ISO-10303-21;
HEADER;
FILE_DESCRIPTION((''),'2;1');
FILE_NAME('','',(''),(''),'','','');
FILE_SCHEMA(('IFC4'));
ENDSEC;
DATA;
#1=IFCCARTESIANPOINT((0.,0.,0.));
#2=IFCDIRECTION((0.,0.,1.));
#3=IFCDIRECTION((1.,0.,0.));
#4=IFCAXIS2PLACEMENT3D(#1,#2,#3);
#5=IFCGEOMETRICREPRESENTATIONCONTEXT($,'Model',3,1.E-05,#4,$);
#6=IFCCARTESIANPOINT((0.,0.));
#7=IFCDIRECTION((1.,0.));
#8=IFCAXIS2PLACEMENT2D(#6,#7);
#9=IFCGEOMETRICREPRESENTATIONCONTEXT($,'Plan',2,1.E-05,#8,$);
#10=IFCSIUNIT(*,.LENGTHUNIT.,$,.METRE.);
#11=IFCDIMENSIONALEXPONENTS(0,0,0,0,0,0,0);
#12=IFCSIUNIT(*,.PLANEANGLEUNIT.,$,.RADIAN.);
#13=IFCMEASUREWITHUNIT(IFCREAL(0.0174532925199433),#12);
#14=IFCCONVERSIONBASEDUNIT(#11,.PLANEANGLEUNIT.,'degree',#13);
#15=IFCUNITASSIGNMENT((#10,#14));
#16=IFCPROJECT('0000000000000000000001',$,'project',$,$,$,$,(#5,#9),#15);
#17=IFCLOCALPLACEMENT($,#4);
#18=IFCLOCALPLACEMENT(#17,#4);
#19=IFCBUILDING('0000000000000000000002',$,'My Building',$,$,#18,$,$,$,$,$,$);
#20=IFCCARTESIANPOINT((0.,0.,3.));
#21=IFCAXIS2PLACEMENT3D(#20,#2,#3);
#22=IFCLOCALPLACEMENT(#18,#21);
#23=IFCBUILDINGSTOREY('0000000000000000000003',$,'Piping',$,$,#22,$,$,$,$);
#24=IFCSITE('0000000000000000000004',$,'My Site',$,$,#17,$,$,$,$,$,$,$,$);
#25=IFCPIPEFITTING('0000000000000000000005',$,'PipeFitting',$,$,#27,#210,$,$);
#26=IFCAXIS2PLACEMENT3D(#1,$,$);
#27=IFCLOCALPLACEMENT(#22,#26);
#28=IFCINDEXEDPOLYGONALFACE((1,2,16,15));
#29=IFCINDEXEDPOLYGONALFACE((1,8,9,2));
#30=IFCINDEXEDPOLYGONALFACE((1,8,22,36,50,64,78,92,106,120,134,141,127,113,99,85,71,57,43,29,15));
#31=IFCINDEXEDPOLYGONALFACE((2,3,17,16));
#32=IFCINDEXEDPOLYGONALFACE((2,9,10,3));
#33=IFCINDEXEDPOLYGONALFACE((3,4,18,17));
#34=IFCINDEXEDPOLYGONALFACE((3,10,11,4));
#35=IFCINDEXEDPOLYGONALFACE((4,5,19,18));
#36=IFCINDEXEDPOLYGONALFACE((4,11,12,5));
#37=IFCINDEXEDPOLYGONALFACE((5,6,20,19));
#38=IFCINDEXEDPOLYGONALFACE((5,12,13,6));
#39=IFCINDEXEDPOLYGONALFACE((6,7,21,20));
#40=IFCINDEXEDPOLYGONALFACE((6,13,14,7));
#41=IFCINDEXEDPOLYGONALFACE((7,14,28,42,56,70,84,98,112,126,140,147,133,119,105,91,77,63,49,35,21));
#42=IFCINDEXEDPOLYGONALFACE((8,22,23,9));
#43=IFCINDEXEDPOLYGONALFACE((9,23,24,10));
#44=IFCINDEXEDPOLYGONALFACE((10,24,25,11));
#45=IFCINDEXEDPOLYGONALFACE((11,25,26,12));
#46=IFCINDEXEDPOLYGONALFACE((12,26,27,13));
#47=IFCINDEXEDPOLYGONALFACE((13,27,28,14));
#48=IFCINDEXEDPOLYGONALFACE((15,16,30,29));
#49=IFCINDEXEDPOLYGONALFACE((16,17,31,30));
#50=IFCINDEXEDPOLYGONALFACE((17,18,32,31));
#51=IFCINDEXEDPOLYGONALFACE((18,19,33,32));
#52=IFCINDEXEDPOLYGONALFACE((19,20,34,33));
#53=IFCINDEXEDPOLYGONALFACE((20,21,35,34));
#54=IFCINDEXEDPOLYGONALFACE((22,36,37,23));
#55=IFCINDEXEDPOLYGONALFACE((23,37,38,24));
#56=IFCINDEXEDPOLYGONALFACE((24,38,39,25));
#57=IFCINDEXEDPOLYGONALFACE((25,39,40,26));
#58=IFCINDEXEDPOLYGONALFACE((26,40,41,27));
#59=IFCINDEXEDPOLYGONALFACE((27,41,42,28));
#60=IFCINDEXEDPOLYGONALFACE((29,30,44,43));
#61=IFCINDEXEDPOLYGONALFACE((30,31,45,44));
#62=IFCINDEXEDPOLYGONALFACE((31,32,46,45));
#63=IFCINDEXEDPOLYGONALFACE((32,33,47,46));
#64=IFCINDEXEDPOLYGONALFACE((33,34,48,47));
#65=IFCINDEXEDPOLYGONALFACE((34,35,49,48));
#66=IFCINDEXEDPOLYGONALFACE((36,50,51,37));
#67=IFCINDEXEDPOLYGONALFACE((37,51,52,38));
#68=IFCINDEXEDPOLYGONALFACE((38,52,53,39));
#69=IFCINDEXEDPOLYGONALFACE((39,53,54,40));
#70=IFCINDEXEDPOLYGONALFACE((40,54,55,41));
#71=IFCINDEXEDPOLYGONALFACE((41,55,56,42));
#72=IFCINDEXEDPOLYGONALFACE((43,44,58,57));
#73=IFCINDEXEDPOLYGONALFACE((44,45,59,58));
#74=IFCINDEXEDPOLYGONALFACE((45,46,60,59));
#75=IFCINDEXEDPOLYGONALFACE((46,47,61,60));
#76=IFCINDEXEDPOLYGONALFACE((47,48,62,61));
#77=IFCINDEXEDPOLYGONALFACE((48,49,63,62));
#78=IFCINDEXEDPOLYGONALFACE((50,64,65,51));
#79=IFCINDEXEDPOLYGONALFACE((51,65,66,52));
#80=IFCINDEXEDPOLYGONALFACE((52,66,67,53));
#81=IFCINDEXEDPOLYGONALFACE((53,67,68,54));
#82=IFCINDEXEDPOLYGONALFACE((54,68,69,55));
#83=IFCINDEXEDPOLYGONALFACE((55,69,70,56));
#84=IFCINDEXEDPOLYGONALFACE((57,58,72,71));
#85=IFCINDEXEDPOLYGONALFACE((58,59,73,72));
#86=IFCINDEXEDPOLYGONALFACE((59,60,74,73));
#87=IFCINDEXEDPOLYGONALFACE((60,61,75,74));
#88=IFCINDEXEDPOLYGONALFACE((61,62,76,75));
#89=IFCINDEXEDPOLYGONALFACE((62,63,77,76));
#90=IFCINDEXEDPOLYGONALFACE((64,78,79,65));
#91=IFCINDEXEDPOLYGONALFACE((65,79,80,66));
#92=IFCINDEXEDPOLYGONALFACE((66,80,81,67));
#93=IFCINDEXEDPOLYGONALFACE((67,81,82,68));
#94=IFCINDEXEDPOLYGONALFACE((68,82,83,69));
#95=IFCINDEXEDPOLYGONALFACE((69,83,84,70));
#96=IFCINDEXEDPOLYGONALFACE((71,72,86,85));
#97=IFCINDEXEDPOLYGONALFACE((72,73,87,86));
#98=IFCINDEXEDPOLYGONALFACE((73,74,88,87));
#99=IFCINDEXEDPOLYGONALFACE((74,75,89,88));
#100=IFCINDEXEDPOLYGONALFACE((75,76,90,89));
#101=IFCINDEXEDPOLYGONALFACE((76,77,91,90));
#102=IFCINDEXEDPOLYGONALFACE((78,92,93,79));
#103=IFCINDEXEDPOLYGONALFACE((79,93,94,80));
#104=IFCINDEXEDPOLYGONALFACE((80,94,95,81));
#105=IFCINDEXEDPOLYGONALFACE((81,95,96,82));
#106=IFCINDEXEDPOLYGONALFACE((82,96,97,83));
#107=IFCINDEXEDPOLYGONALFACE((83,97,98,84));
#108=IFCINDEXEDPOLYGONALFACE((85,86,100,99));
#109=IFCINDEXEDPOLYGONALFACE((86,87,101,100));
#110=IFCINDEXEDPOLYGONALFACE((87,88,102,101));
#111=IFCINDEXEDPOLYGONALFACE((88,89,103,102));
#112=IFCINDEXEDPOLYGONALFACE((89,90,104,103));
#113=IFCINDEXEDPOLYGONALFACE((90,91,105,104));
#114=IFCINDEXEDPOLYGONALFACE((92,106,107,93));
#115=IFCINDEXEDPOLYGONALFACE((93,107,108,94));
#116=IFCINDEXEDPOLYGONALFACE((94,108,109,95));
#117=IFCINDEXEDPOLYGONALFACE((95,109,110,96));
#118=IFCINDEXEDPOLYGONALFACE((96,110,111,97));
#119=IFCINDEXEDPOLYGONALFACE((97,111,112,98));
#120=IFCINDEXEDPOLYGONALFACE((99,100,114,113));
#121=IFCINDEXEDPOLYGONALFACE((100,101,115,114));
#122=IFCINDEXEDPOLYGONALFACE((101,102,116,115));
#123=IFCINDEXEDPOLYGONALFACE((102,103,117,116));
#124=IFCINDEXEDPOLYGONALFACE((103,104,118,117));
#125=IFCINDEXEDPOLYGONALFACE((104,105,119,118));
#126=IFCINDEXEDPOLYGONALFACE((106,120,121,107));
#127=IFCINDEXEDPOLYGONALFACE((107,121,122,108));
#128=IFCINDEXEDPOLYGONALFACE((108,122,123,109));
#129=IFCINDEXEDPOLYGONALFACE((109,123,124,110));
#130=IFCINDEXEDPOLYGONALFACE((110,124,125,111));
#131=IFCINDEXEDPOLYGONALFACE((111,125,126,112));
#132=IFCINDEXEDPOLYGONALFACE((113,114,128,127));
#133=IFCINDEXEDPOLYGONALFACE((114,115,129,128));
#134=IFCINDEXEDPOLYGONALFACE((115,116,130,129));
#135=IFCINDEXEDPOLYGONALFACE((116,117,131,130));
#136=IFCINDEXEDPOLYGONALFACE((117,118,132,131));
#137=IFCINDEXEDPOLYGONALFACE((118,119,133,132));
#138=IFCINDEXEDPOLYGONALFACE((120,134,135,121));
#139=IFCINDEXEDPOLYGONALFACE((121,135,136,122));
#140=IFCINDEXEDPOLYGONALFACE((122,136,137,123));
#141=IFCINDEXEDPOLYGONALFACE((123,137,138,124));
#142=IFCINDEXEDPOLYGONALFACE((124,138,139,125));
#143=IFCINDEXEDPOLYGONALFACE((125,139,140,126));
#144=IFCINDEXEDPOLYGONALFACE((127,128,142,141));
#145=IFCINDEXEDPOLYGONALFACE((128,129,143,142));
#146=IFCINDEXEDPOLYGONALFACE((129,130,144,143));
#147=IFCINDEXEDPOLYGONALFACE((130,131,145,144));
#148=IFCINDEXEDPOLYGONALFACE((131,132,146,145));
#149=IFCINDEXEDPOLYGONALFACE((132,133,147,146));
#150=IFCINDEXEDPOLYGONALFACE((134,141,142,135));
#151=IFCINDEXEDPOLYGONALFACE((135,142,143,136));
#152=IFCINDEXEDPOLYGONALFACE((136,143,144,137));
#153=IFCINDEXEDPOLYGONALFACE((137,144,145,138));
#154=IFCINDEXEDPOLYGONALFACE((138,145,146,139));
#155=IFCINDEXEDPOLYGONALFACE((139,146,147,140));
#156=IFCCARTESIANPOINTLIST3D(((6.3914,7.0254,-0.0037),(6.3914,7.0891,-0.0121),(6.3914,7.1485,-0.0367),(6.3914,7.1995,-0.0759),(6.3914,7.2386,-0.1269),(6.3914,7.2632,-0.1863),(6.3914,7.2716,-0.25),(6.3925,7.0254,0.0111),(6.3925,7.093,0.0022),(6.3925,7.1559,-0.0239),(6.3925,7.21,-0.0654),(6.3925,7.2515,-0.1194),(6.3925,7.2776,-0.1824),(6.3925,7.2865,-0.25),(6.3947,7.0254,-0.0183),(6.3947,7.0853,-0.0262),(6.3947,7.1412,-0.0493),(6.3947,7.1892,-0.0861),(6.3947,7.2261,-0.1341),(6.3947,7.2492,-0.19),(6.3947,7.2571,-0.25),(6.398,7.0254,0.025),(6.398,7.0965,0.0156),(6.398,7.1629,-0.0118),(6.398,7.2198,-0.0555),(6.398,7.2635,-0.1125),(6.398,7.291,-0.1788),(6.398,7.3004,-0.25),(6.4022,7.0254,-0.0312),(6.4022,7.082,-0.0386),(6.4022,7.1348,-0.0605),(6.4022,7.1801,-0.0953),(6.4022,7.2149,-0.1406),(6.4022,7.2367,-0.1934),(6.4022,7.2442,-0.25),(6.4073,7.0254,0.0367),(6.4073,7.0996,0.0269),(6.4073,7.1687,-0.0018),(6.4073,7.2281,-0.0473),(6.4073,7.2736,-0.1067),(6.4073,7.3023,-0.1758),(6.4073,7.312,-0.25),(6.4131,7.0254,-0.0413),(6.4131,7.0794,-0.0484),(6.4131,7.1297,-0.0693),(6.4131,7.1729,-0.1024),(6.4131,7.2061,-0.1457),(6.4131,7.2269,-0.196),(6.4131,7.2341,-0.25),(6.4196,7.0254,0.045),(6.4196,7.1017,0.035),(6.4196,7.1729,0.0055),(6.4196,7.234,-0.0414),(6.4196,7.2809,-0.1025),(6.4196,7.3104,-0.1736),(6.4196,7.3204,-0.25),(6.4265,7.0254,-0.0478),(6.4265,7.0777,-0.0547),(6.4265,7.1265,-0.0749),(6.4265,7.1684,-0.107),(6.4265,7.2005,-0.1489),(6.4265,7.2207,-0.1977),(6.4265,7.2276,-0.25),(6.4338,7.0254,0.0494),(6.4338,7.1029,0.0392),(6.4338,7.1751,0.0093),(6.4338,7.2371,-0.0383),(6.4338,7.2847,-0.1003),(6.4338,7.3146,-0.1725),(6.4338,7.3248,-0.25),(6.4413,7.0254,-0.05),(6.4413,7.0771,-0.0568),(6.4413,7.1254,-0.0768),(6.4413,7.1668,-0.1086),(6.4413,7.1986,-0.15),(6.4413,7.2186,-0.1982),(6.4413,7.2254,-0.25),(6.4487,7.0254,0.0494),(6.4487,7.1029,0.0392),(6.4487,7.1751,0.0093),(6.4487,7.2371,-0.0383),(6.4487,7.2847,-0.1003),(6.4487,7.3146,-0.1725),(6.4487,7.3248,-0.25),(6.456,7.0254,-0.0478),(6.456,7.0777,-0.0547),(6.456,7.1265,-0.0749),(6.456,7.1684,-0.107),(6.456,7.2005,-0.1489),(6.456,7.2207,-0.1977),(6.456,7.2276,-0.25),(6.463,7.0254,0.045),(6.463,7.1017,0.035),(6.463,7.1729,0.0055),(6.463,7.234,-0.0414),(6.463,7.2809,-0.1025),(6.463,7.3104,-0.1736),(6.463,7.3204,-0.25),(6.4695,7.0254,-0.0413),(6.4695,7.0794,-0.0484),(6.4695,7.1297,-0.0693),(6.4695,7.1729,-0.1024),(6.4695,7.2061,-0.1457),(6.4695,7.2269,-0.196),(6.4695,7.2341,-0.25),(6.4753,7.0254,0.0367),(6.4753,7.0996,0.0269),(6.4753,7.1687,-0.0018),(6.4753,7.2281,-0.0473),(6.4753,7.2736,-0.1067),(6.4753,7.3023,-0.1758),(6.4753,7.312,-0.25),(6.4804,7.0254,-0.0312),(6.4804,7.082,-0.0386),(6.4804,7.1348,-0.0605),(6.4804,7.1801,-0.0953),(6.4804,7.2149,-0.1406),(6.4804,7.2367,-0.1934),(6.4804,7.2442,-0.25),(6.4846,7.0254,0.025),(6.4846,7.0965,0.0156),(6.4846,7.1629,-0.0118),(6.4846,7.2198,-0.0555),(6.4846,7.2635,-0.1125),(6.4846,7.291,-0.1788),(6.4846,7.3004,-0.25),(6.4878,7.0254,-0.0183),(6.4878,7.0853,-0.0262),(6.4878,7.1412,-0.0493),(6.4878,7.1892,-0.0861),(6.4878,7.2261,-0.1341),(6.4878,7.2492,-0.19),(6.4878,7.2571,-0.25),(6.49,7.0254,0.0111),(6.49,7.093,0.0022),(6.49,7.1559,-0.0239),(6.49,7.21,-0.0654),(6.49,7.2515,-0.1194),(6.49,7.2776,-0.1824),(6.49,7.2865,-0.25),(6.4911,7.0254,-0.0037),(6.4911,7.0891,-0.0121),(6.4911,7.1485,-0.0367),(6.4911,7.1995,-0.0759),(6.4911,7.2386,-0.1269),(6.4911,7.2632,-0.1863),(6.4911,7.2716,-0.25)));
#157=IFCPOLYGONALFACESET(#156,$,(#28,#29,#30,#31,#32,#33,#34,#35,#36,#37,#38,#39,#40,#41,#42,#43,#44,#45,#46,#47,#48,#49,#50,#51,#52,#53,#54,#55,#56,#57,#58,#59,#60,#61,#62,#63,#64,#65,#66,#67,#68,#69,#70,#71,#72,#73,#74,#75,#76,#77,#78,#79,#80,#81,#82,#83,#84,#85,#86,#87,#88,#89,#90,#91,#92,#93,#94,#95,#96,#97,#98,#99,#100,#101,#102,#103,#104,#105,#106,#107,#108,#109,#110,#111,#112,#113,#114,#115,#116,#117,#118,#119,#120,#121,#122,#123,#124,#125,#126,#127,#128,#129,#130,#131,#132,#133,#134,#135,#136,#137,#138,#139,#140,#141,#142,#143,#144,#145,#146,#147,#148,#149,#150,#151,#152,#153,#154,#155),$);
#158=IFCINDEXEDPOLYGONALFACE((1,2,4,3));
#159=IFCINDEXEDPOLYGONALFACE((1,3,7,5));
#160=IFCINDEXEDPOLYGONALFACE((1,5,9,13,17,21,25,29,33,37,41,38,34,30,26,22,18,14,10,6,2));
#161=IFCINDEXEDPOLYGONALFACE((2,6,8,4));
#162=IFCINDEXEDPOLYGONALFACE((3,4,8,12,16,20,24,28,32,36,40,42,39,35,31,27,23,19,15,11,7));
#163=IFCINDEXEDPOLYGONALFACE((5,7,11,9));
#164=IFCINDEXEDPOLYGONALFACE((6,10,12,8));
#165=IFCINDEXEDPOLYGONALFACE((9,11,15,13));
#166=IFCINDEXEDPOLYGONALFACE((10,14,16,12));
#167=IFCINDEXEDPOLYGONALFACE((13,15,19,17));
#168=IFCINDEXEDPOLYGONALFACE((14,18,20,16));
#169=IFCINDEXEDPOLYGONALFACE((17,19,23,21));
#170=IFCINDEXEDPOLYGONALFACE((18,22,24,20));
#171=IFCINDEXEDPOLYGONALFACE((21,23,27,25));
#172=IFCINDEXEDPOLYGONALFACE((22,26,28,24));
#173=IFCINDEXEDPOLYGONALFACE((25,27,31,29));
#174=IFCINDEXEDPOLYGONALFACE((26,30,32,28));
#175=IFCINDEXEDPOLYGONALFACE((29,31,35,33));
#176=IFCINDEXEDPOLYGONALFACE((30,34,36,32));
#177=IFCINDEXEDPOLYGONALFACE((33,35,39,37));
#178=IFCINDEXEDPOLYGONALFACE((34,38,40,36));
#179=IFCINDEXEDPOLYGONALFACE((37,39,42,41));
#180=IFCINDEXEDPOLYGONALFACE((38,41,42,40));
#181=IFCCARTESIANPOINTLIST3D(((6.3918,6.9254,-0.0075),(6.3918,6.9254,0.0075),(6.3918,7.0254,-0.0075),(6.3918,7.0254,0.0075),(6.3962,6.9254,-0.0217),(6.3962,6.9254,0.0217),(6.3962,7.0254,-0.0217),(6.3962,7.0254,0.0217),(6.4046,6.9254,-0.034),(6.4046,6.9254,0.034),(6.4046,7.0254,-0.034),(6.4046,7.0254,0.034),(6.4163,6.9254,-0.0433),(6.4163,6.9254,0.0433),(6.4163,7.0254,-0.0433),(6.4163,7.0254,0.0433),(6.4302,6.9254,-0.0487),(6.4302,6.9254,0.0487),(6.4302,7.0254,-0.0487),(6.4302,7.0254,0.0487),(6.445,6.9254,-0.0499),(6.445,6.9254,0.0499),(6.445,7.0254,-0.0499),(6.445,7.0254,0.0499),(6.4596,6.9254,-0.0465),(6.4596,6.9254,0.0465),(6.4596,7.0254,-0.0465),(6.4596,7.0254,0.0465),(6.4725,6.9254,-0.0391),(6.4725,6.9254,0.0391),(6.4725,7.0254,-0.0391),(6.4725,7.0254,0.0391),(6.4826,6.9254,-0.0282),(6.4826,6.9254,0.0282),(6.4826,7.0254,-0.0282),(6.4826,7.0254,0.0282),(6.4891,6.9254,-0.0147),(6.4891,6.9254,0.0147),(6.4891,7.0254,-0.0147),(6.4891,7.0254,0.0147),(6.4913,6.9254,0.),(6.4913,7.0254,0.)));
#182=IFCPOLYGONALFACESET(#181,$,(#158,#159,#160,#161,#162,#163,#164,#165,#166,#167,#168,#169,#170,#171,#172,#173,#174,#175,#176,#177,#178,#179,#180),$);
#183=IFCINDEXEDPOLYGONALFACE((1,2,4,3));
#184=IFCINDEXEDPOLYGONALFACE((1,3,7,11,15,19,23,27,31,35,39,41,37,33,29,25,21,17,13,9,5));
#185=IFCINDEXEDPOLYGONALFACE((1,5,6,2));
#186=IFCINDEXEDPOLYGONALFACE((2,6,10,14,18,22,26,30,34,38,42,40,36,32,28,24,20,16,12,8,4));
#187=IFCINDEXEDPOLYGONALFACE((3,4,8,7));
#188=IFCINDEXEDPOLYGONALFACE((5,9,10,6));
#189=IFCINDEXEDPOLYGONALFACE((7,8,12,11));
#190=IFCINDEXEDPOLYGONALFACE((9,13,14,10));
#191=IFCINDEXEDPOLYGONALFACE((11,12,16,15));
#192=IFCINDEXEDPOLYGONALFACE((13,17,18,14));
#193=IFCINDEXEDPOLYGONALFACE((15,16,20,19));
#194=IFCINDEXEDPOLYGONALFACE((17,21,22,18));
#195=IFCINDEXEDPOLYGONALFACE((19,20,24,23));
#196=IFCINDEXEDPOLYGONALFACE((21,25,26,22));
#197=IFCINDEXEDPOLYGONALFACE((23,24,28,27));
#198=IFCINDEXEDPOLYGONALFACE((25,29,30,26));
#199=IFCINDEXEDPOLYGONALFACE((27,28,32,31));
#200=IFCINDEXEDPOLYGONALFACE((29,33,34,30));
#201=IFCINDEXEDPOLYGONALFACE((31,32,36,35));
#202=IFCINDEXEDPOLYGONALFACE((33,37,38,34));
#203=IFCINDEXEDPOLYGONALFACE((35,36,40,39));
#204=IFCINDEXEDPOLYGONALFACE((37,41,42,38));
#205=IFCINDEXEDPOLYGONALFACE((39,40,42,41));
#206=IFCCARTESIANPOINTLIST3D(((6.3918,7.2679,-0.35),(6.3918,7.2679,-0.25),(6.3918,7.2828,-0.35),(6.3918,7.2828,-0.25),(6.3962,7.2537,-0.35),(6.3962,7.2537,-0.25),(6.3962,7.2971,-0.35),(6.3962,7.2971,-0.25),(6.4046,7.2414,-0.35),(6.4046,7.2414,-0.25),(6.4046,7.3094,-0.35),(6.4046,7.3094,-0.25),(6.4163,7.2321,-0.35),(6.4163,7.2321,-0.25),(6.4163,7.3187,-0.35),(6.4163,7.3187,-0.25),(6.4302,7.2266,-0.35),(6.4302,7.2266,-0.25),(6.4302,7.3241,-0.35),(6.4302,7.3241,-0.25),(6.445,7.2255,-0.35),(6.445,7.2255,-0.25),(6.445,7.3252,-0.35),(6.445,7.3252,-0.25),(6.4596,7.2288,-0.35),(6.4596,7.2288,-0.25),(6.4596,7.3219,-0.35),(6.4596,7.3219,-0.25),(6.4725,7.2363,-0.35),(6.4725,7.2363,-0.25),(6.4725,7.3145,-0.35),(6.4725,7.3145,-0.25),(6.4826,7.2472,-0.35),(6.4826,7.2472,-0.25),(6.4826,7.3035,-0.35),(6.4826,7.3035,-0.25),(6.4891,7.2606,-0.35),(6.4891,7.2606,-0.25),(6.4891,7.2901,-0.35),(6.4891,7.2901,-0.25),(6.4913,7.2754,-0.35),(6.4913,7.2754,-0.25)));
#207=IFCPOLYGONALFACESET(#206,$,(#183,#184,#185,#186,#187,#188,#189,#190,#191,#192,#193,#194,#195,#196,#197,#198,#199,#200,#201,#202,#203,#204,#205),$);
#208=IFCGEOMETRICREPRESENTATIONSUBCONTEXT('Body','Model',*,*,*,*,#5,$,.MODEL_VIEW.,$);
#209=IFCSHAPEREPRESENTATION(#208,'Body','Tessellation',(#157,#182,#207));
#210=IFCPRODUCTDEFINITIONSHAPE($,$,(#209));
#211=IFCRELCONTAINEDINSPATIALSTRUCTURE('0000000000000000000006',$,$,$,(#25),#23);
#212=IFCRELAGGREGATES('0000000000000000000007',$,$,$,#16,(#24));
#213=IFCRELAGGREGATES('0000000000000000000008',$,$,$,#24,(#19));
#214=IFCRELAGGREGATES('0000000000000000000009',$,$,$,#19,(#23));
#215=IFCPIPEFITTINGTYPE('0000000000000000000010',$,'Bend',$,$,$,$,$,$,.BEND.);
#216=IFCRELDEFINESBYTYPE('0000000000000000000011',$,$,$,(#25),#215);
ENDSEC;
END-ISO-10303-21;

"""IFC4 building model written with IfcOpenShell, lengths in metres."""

from ifc_helpers import new_model, entity, si_unit, converted_unit, frame, origin_with_axes, origin_2d_with_axis, place, context, subcontext, project, spatial, circle, extrude, source, transform, mapped, type_object, type_shapes, element, save


model = new_model("IFC4")

# Units and contexts
model_context = context("Model", 3, precision=1e-05, world=origin_with_axes())
plan_context = context("Plan", 2, precision=1e-05, world=origin_2d_with_axis())
body_context = subcontext(model_context, "Body", "Model", "MODEL_VIEW")
ifc_project = project(units=[si_unit("LENGTHUNIT", "METRE"), converted_unit("PLANEANGLEUNIT", "degree", entity("IfcReal", 0.0174532925199433), si_unit("PLANEANGLEUNIT", "RADIAN"), dimensions=[0, 0, 0, 0, 0, 0, 0])], contexts=[model_context, plan_context])

# Site, building, storey
site_placement = place(None, origin_with_axes())
site = spatial("IfcSite", under=ifc_project, at=site_placement, Name="My Site")
building_placement = place(site_placement, origin_with_axes())
building = spatial("IfcBuilding", under=site, at=building_placement, Name="My Building")
storey_placement = place(building_placement, frame((0.0, 0.0, 3.0), z_axis=(0.0, 0.0, 1.0), x_axis=(1.0, 0.0, 0.0)))
storey = spatial("IfcBuildingStorey", under=building, at=storey_placement, Name="Piping")

# Pipe fitting
pipe_fitting_type = type_object("IfcPipeFittingType", Name="Bend", PredefinedType="BEND")
shared_shape = source(origin_with_axes(), body_context, "Body", "SolidModel", [
    entity("IfcSweptDiskSolid", entity("IfcIndexedPolyCurve", entity("IfcCartesianPointList3D", [[0.0, 0.0, -0.1], [0.0, -0.0732, -0.2768], [0.0, -0.25, -0.35]]), [entity("IfcArcIndex", [1, 2, 3])]), 0.05),
    extrude(circle(Radius=0.05), origin_with_axes(), (0.0, 0.0, -1.0), 0.1),
    extrude(circle(Radius=0.05), frame((0.0, -0.25, -0.35), z_axis=(0.0, -1.0, 0.0), x_axis=(1.0, 0.0, 0.0)), (0.0, 0.0, 1.0), 0.1),
])
type_shapes(pipe_fitting_type, [shared_shape])
for number, where, z_axis, x_axis, name in (
    (1, (6.4413, 6.9254, 0.0), (0.0, -1.0, 0.0), (1.0, 0.0, 0.0), "PipeFitting"),
):
    element("IfcPipeFitting", number, at=place(storey_placement, frame(where, z_axis=z_axis, x_axis=x_axis)), inside=storey, type_object=pipe_fitting_type, Name=name, context=body_context, shape_type="MappedRepresentation", body=[
        mapped(shared_shape, transform((0.0, 0.0, 0.0), x_axis=(1.0, 0.0, 0.0), y_axis=(0.0, 1.0, 0.0), z_axis=(0.0, 0.0, 1.0), scale=1.0)),
    ])

save(model, "model.ifc")
